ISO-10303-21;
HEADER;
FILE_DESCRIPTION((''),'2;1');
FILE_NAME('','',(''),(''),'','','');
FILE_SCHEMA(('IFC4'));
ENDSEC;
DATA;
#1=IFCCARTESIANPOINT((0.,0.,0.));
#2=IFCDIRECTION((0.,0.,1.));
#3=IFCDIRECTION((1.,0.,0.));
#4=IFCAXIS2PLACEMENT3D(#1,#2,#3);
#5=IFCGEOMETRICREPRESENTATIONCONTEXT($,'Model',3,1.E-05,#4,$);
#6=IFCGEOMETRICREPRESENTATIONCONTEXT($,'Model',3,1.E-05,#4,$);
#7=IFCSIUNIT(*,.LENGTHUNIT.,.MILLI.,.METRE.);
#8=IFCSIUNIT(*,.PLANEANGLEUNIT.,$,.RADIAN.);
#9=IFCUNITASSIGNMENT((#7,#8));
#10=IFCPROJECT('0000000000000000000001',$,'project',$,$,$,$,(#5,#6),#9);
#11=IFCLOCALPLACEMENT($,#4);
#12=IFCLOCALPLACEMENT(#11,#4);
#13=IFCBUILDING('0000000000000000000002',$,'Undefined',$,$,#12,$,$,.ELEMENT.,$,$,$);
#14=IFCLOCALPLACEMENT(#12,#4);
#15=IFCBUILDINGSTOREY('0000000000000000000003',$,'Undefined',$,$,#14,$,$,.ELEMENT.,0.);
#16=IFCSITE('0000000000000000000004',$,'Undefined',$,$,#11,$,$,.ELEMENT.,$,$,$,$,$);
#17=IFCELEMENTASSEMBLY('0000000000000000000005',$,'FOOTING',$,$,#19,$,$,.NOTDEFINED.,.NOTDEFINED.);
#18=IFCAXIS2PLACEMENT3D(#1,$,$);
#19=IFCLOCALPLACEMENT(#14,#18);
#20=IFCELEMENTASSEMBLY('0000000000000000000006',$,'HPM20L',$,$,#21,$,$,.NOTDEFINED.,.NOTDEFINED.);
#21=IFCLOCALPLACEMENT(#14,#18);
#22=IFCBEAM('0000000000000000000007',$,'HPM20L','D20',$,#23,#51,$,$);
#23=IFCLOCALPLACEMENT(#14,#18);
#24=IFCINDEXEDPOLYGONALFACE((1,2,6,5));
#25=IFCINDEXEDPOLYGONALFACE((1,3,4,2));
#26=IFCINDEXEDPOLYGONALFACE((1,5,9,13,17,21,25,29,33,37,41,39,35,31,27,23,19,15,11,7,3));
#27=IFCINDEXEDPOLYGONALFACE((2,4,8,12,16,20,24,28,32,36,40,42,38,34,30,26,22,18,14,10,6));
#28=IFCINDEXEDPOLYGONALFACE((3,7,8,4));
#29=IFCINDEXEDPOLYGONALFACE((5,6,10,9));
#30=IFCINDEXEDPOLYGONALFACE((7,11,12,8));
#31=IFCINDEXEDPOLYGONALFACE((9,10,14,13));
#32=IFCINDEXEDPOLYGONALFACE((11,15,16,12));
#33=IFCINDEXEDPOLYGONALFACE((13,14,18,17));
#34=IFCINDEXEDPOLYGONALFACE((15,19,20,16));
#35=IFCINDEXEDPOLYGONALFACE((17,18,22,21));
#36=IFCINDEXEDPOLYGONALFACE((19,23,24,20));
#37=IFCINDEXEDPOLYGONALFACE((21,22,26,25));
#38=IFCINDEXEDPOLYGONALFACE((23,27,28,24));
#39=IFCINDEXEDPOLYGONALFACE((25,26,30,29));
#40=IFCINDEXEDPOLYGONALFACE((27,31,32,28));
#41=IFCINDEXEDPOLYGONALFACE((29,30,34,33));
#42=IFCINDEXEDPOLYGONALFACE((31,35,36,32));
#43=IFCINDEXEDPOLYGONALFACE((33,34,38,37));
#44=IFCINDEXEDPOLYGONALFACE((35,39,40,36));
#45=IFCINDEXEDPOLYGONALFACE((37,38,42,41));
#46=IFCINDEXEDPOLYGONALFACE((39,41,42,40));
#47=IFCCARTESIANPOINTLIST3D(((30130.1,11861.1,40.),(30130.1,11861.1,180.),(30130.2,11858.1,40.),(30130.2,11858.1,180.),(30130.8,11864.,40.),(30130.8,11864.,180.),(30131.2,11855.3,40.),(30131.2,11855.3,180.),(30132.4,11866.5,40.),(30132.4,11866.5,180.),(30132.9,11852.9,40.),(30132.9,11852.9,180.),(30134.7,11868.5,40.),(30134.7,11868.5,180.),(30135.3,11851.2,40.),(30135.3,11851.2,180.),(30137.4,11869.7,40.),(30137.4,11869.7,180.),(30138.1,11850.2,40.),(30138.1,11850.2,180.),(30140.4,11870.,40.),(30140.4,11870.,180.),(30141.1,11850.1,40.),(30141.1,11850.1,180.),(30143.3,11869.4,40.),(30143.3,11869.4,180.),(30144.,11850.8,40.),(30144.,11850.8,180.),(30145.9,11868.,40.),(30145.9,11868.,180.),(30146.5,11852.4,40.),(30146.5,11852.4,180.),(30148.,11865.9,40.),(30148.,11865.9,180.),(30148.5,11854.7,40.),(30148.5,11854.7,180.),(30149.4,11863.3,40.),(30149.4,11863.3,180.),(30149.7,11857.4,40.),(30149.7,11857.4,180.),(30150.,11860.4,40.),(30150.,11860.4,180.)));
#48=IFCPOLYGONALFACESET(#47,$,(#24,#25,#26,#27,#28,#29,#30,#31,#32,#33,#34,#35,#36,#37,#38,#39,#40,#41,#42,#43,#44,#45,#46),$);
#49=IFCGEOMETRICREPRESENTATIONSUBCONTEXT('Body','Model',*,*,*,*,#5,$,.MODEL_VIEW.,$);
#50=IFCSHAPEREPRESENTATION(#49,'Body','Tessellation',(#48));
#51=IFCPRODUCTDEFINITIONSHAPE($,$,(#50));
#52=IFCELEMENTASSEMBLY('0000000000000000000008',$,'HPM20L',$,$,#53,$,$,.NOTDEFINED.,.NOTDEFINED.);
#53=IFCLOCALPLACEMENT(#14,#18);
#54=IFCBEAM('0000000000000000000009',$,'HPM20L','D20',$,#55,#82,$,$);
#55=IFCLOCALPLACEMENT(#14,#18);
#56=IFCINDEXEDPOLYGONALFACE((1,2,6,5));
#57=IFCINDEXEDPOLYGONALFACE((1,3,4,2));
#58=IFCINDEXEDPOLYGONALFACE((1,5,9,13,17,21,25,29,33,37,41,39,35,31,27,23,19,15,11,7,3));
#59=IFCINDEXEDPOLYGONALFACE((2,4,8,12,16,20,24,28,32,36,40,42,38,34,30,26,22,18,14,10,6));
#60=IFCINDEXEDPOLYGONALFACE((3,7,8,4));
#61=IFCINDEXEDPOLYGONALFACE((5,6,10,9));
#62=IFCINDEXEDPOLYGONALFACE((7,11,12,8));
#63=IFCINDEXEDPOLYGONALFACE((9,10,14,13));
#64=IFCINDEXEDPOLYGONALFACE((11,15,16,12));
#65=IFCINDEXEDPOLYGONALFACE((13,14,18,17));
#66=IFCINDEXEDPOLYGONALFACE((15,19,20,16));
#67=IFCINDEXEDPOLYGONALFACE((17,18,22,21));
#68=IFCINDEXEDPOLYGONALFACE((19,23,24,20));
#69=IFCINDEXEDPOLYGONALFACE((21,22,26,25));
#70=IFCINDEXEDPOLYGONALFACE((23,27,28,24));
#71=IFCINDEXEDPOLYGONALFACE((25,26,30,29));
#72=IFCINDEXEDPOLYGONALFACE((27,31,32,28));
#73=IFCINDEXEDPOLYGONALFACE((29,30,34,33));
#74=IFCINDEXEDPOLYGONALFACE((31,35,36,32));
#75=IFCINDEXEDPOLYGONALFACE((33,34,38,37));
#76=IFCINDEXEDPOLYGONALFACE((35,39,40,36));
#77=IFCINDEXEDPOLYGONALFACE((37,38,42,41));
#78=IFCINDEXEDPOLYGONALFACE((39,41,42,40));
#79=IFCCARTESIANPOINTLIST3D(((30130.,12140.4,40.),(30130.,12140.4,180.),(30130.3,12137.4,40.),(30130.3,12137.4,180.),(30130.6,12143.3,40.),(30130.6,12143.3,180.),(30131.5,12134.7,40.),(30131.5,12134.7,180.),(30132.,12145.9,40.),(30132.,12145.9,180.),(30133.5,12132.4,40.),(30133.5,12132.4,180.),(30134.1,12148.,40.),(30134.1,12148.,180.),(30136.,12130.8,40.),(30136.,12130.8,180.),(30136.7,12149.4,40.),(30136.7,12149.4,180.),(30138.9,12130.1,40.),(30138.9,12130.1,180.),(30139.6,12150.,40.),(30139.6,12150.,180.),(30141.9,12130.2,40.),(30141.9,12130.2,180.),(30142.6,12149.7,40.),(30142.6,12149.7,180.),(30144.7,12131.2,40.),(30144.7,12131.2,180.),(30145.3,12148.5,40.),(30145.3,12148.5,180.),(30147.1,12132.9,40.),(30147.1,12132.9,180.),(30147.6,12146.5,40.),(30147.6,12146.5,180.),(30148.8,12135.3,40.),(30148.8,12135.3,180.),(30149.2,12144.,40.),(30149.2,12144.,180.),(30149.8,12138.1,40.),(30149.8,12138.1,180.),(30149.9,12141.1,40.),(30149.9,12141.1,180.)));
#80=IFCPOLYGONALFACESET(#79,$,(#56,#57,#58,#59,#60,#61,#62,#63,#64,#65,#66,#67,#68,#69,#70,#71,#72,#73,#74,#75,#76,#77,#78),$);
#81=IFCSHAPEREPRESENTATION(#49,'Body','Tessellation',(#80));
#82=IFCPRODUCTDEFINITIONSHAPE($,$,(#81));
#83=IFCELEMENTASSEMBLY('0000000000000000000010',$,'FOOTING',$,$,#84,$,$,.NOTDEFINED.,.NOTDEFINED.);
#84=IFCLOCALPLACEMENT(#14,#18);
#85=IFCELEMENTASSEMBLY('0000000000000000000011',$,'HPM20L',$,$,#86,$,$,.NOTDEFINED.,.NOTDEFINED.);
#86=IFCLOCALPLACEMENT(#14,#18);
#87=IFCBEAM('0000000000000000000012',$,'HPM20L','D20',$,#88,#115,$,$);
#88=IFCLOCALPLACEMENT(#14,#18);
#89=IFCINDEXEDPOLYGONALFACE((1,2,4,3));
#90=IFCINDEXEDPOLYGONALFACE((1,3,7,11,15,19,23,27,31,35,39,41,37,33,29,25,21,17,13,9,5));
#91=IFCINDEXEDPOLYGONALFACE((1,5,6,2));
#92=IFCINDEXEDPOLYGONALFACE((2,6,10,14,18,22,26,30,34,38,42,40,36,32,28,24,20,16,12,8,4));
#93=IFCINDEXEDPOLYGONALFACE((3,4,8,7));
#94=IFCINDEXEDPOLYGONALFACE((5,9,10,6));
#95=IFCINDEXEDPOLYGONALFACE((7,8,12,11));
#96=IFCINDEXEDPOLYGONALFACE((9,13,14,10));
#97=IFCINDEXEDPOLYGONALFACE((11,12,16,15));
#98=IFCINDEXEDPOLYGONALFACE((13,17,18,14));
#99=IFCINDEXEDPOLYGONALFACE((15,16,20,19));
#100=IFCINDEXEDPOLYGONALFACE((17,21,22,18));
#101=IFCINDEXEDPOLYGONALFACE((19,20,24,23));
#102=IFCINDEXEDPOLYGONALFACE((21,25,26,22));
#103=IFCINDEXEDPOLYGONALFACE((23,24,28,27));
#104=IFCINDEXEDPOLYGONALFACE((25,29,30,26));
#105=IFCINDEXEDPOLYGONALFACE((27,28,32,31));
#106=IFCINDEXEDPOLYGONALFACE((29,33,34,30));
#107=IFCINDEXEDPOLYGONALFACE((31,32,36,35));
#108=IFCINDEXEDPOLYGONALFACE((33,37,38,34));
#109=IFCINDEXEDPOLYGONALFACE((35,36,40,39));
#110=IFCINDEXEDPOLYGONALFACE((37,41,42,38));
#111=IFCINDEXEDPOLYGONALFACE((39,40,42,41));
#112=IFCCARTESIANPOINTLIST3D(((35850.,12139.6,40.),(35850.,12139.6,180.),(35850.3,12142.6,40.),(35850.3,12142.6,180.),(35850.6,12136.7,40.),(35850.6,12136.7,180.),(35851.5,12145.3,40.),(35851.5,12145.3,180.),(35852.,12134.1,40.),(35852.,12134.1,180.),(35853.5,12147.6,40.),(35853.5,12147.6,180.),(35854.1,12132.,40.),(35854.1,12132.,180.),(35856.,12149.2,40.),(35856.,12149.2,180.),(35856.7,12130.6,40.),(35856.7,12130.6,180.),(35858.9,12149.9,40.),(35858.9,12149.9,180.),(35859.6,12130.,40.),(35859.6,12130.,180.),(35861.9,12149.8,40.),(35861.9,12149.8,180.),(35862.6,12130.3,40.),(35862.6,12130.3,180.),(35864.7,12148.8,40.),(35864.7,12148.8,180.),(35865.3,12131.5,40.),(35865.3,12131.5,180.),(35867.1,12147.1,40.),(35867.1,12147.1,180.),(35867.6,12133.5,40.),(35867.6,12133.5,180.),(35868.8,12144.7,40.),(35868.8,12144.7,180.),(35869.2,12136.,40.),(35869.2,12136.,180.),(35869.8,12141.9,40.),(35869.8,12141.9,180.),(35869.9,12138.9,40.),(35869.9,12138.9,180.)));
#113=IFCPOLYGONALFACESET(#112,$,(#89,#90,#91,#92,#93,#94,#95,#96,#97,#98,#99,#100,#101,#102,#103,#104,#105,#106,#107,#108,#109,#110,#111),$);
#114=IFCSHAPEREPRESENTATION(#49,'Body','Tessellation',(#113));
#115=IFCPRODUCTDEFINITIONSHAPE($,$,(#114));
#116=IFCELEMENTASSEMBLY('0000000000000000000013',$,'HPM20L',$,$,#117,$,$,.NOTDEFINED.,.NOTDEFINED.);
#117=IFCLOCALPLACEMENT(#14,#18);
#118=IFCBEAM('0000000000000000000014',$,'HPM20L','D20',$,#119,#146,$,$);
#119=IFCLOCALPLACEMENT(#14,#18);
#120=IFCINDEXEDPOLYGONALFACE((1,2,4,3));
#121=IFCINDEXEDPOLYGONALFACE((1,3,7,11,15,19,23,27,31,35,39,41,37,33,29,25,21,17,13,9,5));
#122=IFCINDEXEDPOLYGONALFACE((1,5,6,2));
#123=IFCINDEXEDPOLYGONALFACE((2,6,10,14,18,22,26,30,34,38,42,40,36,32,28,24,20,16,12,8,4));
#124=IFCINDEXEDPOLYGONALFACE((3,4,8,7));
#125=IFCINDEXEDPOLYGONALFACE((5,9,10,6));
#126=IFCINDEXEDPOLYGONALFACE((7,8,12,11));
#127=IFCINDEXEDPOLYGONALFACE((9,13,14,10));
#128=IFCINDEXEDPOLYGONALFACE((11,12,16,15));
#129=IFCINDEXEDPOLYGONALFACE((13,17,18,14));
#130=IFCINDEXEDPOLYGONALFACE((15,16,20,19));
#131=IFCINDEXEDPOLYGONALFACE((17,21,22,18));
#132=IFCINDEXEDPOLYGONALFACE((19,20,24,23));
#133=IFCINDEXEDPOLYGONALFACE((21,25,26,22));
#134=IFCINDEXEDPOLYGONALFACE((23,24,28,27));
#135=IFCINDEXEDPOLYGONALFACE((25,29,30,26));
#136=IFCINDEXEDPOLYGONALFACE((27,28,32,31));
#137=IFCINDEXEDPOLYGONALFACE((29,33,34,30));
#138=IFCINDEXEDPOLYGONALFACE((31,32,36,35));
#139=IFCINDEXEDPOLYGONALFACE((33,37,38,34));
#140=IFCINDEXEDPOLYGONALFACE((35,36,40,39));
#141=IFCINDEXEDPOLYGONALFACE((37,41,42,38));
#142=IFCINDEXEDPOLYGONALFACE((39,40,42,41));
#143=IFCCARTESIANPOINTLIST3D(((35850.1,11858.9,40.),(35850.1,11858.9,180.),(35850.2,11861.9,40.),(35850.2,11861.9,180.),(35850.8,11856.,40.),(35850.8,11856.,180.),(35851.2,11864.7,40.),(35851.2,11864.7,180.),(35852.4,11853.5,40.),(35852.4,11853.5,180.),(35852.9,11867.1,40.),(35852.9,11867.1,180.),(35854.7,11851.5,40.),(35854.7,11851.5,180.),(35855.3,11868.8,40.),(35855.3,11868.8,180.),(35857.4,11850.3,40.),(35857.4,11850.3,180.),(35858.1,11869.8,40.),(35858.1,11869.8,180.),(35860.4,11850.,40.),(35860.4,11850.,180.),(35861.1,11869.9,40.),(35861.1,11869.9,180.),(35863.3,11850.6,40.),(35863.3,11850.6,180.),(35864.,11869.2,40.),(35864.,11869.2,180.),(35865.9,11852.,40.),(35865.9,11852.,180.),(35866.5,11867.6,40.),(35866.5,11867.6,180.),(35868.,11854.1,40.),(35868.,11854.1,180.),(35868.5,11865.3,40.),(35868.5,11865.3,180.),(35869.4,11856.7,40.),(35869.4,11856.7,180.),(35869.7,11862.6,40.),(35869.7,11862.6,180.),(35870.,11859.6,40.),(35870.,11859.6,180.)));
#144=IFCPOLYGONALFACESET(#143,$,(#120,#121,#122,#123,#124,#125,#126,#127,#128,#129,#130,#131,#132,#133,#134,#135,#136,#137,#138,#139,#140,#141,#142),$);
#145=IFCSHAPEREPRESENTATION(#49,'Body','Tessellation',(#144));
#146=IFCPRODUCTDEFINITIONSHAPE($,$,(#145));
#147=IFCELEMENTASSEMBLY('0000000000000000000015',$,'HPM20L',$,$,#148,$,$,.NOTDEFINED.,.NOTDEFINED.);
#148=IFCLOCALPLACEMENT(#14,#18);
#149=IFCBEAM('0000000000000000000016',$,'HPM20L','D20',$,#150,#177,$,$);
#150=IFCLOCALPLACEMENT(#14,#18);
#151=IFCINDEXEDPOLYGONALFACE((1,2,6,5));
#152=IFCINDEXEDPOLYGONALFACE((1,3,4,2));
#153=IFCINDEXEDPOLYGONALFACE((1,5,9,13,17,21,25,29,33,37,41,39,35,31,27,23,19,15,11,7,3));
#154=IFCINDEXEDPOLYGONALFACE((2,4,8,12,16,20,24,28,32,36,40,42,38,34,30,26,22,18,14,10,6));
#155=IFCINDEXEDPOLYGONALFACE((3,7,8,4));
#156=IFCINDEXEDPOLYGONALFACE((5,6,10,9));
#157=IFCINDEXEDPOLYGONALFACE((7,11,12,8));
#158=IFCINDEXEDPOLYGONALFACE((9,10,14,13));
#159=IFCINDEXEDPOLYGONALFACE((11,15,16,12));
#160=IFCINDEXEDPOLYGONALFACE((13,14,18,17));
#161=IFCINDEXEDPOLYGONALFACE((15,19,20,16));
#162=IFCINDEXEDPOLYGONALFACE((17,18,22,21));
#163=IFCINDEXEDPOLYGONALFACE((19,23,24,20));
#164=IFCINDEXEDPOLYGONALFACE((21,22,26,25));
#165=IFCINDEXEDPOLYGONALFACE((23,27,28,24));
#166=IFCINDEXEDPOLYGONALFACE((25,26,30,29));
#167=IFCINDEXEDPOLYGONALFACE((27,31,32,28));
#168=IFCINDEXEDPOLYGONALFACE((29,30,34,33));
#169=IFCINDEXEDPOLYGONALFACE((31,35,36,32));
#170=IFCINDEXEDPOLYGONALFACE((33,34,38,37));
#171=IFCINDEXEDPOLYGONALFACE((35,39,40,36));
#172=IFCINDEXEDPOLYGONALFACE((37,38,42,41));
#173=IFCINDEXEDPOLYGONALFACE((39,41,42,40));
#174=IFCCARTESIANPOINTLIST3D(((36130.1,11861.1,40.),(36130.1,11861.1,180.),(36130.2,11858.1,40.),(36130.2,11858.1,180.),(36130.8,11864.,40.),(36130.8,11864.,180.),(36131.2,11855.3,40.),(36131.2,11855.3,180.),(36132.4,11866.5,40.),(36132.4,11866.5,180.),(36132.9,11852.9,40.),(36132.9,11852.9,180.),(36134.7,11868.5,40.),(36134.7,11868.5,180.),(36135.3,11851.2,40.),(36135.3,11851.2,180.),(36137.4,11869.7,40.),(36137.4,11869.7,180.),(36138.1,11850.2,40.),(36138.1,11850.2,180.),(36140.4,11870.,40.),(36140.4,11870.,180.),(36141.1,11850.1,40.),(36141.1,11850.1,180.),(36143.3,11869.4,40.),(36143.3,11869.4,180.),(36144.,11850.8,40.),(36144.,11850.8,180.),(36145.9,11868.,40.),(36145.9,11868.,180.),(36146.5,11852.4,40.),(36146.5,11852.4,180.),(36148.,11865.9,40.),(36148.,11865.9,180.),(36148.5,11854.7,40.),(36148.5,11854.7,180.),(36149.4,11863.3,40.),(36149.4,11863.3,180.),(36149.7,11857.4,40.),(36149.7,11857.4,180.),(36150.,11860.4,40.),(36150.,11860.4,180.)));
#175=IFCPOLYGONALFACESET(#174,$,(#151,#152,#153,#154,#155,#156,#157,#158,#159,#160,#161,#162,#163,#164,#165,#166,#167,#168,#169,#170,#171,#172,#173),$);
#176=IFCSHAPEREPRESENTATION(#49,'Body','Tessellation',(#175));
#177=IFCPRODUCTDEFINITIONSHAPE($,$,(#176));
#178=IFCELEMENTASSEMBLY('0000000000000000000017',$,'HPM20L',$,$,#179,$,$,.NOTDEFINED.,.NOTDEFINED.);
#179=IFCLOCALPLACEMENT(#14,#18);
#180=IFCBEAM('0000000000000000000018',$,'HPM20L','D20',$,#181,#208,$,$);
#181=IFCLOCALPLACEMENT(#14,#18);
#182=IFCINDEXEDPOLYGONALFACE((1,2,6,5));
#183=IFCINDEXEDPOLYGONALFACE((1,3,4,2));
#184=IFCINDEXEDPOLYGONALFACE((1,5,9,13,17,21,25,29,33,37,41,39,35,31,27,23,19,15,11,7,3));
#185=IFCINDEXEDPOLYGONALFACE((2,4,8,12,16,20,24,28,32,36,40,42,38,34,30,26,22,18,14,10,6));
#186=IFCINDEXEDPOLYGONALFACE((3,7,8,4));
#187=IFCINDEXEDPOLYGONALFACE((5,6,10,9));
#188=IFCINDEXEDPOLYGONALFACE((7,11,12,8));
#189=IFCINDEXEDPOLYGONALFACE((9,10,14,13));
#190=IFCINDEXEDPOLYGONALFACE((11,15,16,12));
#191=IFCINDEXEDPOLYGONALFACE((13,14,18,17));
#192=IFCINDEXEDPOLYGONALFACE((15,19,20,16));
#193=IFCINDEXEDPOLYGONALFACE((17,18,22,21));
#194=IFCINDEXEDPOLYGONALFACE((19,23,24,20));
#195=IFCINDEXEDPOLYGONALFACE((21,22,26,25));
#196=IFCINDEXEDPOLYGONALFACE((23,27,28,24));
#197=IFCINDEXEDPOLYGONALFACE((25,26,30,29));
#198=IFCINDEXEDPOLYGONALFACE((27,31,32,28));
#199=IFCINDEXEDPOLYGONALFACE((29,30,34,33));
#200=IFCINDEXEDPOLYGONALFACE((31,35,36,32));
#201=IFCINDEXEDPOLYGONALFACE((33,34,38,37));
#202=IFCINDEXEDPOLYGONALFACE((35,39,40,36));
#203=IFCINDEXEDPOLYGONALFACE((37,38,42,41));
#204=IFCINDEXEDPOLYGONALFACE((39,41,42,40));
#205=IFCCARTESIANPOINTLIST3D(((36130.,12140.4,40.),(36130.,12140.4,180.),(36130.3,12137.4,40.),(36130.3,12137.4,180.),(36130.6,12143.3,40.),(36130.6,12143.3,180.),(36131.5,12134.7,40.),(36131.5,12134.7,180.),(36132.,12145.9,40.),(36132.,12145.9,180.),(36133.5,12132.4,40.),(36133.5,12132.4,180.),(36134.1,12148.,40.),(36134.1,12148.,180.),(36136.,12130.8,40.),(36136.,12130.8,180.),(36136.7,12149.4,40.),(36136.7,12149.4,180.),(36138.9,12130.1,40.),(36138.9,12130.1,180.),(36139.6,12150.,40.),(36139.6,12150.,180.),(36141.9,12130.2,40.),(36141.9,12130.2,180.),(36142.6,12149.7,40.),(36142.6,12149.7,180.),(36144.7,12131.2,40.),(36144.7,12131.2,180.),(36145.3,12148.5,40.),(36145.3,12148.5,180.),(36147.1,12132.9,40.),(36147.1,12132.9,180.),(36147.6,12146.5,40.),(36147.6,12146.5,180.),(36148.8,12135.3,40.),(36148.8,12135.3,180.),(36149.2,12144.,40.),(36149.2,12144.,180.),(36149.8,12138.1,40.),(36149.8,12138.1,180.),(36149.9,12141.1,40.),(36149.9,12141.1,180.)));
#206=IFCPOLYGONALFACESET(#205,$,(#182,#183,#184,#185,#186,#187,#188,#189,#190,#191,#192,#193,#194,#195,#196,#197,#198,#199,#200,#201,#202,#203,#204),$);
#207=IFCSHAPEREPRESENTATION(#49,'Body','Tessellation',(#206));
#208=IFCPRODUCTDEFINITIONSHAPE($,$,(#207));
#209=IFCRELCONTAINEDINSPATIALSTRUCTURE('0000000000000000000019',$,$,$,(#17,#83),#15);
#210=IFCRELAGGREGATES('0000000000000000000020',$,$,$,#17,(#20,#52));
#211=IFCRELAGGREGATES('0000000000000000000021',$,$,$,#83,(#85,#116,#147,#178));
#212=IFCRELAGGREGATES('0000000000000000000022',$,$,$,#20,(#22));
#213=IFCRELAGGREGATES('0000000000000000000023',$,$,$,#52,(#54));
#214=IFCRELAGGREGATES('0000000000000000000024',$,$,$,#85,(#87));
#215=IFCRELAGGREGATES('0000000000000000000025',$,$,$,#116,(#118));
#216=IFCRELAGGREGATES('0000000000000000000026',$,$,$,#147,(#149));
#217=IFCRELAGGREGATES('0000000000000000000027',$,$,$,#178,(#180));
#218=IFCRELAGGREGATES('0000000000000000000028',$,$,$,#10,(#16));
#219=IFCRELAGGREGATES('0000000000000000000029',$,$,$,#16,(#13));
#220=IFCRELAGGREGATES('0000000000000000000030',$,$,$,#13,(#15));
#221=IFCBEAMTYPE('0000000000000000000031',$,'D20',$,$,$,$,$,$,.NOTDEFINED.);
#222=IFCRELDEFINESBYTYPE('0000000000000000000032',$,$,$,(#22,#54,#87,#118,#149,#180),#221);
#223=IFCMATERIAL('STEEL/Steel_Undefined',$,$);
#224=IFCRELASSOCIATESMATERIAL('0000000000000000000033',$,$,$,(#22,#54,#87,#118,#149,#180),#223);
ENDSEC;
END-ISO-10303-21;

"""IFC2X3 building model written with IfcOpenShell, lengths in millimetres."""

from ifc_helpers import new_model, si_unit, frame, origin_with_axes, origin_2d_with_axis, place, context, subcontext, project, spatial, circle, extrude, material, type_object, element, aggregate, save


model = new_model("IFC2X3")

# Units and contexts
model_context_1 = context("Model", 3, precision=1e-05, world=origin_with_axes())
model_context_2 = context("Model", 3, precision=1e-05, world=origin_with_axes())
body_context = subcontext(model_context_1, "Body", "Model", "MODEL_VIEW")
ifc_project = project(units=[si_unit("LENGTHUNIT", "METRE", prefix="MILLI"), si_unit("PLANEANGLEUNIT", "RADIAN")], contexts=[model_context_1, model_context_2])

# Site, building, storey
site_placement = place(None, origin_with_axes())
site = spatial("IfcSite", under=ifc_project, at=site_placement, Name="Undefined", CompositionType="ELEMENT")
building_placement = place(site_placement, origin_with_axes())
building = spatial("IfcBuilding", under=site, at=building_placement, Name="Undefined", CompositionType="ELEMENT")
storey_placement = place(building_placement, origin_with_axes())
storey = spatial("IfcBuildingStorey", under=building, at=storey_placement, Name="Undefined", CompositionType="ELEMENT", Elevation=0.0)

# Element assemblies, beams
assembly_1_placement = place(storey_placement, origin_with_axes())
assembly_1 = element("IfcElementAssembly", 1, at=assembly_1_placement, inside=storey, Name="FOOTING", AssemblyPlace="NOTDEFINED", PredefinedType="NOTDEFINED")
assembly_2_placement = place(assembly_1_placement, origin_with_axes())
assembly_2 = element("IfcElementAssembly", 2, at=assembly_2_placement, Name="HPM20L", AssemblyPlace="NOTDEFINED", PredefinedType="NOTDEFINED")
ifc_material_1 = material(Name="STEEL/Steel_Undefined")
beam_type = type_object("IfcBeamType", Name="D20", PredefinedType="NOTDEFINED")
beam_1_placement = place(assembly_2_placement, frame((30140.0, 11860.0, 180.0), z_axis=(0.707107, -0.707107, 0.0), x_axis=(0.0, 0.0, -1.0)))
beam_1 = element("IfcBeam", 3, at=beam_1_placement, type_object=beam_type, material=ifc_material_1, Name="HPM20L", Description="D20", context=body_context, shape_type="SweptSolid", body=[
    extrude(circle(Radius=10.0, at=origin_2d_with_axis()), frame((140.0, 0.0, 0.0), z_axis=(-1.0, 0.0, 0.0), x_axis=(0.0, -1.0, 0.0)), (0.0, 0.0, 1.0), 140.0),
])
assembly_3_placement = place(assembly_1_placement, origin_with_axes())
assembly_3 = element("IfcElementAssembly", 4, at=assembly_3_placement, Name="HPM20L", AssemblyPlace="NOTDEFINED", PredefinedType="NOTDEFINED")
aggregate(assembly_1, [assembly_2, assembly_3])
beam_2_placement = place(assembly_3_placement, frame((30140.0, 12140.0, 180.0), z_axis=(0.707107, 0.707107, 0.0), x_axis=(0.0, 0.0, -1.0)))
beam_2 = element("IfcBeam", 5, at=beam_2_placement, type_object=beam_type, material=ifc_material_1, Name="HPM20L", Description="D20", context=body_context, shape_type="SweptSolid", body=[
    extrude(circle(Radius=10.0, at=origin_2d_with_axis()), frame((140.0, 0.0, 0.0), z_axis=(-1.0, 0.0, 0.0), x_axis=(0.0, -1.0, 0.0)), (0.0, 0.0, 1.0), 140.0),
])
assembly_4_placement = place(storey_placement, origin_with_axes())
assembly_4 = element("IfcElementAssembly", 6, at=assembly_4_placement, inside=storey, Name="FOOTING", AssemblyPlace="NOTDEFINED", PredefinedType="NOTDEFINED")
assembly_5_placement = place(assembly_4_placement, origin_with_axes())
assembly_5 = element("IfcElementAssembly", 7, at=assembly_5_placement, Name="HPM20L", AssemblyPlace="NOTDEFINED", PredefinedType="NOTDEFINED")
beam_3_placement = place(assembly_5_placement, frame((35860.0, 12140.0, 180.0), z_axis=(-0.707107, 0.707107, 0.0), x_axis=(0.0, 0.0, -1.0)))
beam_3 = element("IfcBeam", 8, at=beam_3_placement, type_object=beam_type, material=ifc_material_1, Name="HPM20L", Description="D20", context=body_context, shape_type="SweptSolid", body=[
    extrude(circle(Radius=10.0, at=origin_2d_with_axis()), frame((140.0, 0.0, 0.0), z_axis=(-1.0, 0.0, 0.0), x_axis=(0.0, -1.0, 0.0)), (0.0, 0.0, 1.0), 140.0),
])
assembly_6_placement = place(assembly_4_placement, origin_with_axes())
assembly_6 = element("IfcElementAssembly", 9, at=assembly_6_placement, Name="HPM20L", AssemblyPlace="NOTDEFINED", PredefinedType="NOTDEFINED")
beam_4_placement = place(assembly_6_placement, frame((35860.0, 11860.0, 180.0), z_axis=(-0.707107, -0.707107, 0.0), x_axis=(0.0, 0.0, -1.0)))
beam_4 = element("IfcBeam", 10, at=beam_4_placement, type_object=beam_type, material=ifc_material_1, Name="HPM20L", Description="D20", context=body_context, shape_type="SweptSolid", body=[
    extrude(circle(Radius=10.0, at=origin_2d_with_axis()), frame((140.0, 0.0, 0.0), z_axis=(-1.0, 0.0, 0.0), x_axis=(0.0, -1.0, 0.0)), (0.0, 0.0, 1.0), 140.0),
])
assembly_7_placement = place(assembly_4_placement, origin_with_axes())
assembly_7 = element("IfcElementAssembly", 11, at=assembly_7_placement, Name="HPM20L", AssemblyPlace="NOTDEFINED", PredefinedType="NOTDEFINED")
beam_5_placement = place(assembly_7_placement, frame((36140.0, 11860.0, 180.0), z_axis=(0.707107, -0.707107, 0.0), x_axis=(0.0, 0.0, -1.0)))
beam_5 = element("IfcBeam", 12, at=beam_5_placement, type_object=beam_type, material=ifc_material_1, Name="HPM20L", Description="D20", context=body_context, shape_type="SweptSolid", body=[
    extrude(circle(Radius=10.0, at=origin_2d_with_axis()), frame((140.0, 0.0, 0.0), z_axis=(-1.0, 0.0, 0.0), x_axis=(0.0, -1.0, 0.0)), (0.0, 0.0, 1.0), 140.0),
])
assembly_8_placement = place(assembly_4_placement, origin_with_axes())
assembly_8 = element("IfcElementAssembly", 13, at=assembly_8_placement, Name="HPM20L", AssemblyPlace="NOTDEFINED", PredefinedType="NOTDEFINED")
aggregate(assembly_4, [assembly_5, assembly_6, assembly_7, assembly_8])
beam_6_placement = place(assembly_8_placement, frame((36140.0, 12140.0, 180.0), z_axis=(0.707107, 0.707107, 0.0), x_axis=(0.0, 0.0, -1.0)))
beam_6 = element("IfcBeam", 14, at=beam_6_placement, type_object=beam_type, material=ifc_material_1, Name="HPM20L", Description="D20", context=body_context, shape_type="SweptSolid", body=[
    extrude(circle(Radius=10.0, at=origin_2d_with_axis()), frame((140.0, 0.0, 0.0), z_axis=(-1.0, 0.0, 0.0), x_axis=(0.0, -1.0, 0.0)), (0.0, 0.0, 1.0), 140.0),
])

aggregate(assembly_2, [beam_1])
aggregate(assembly_3, [beam_2])

aggregate(assembly_5, [beam_3])
aggregate(assembly_6, [beam_4])
aggregate(assembly_7, [beam_5])
aggregate(assembly_8, [beam_6])

save(model, "model.ifc")
